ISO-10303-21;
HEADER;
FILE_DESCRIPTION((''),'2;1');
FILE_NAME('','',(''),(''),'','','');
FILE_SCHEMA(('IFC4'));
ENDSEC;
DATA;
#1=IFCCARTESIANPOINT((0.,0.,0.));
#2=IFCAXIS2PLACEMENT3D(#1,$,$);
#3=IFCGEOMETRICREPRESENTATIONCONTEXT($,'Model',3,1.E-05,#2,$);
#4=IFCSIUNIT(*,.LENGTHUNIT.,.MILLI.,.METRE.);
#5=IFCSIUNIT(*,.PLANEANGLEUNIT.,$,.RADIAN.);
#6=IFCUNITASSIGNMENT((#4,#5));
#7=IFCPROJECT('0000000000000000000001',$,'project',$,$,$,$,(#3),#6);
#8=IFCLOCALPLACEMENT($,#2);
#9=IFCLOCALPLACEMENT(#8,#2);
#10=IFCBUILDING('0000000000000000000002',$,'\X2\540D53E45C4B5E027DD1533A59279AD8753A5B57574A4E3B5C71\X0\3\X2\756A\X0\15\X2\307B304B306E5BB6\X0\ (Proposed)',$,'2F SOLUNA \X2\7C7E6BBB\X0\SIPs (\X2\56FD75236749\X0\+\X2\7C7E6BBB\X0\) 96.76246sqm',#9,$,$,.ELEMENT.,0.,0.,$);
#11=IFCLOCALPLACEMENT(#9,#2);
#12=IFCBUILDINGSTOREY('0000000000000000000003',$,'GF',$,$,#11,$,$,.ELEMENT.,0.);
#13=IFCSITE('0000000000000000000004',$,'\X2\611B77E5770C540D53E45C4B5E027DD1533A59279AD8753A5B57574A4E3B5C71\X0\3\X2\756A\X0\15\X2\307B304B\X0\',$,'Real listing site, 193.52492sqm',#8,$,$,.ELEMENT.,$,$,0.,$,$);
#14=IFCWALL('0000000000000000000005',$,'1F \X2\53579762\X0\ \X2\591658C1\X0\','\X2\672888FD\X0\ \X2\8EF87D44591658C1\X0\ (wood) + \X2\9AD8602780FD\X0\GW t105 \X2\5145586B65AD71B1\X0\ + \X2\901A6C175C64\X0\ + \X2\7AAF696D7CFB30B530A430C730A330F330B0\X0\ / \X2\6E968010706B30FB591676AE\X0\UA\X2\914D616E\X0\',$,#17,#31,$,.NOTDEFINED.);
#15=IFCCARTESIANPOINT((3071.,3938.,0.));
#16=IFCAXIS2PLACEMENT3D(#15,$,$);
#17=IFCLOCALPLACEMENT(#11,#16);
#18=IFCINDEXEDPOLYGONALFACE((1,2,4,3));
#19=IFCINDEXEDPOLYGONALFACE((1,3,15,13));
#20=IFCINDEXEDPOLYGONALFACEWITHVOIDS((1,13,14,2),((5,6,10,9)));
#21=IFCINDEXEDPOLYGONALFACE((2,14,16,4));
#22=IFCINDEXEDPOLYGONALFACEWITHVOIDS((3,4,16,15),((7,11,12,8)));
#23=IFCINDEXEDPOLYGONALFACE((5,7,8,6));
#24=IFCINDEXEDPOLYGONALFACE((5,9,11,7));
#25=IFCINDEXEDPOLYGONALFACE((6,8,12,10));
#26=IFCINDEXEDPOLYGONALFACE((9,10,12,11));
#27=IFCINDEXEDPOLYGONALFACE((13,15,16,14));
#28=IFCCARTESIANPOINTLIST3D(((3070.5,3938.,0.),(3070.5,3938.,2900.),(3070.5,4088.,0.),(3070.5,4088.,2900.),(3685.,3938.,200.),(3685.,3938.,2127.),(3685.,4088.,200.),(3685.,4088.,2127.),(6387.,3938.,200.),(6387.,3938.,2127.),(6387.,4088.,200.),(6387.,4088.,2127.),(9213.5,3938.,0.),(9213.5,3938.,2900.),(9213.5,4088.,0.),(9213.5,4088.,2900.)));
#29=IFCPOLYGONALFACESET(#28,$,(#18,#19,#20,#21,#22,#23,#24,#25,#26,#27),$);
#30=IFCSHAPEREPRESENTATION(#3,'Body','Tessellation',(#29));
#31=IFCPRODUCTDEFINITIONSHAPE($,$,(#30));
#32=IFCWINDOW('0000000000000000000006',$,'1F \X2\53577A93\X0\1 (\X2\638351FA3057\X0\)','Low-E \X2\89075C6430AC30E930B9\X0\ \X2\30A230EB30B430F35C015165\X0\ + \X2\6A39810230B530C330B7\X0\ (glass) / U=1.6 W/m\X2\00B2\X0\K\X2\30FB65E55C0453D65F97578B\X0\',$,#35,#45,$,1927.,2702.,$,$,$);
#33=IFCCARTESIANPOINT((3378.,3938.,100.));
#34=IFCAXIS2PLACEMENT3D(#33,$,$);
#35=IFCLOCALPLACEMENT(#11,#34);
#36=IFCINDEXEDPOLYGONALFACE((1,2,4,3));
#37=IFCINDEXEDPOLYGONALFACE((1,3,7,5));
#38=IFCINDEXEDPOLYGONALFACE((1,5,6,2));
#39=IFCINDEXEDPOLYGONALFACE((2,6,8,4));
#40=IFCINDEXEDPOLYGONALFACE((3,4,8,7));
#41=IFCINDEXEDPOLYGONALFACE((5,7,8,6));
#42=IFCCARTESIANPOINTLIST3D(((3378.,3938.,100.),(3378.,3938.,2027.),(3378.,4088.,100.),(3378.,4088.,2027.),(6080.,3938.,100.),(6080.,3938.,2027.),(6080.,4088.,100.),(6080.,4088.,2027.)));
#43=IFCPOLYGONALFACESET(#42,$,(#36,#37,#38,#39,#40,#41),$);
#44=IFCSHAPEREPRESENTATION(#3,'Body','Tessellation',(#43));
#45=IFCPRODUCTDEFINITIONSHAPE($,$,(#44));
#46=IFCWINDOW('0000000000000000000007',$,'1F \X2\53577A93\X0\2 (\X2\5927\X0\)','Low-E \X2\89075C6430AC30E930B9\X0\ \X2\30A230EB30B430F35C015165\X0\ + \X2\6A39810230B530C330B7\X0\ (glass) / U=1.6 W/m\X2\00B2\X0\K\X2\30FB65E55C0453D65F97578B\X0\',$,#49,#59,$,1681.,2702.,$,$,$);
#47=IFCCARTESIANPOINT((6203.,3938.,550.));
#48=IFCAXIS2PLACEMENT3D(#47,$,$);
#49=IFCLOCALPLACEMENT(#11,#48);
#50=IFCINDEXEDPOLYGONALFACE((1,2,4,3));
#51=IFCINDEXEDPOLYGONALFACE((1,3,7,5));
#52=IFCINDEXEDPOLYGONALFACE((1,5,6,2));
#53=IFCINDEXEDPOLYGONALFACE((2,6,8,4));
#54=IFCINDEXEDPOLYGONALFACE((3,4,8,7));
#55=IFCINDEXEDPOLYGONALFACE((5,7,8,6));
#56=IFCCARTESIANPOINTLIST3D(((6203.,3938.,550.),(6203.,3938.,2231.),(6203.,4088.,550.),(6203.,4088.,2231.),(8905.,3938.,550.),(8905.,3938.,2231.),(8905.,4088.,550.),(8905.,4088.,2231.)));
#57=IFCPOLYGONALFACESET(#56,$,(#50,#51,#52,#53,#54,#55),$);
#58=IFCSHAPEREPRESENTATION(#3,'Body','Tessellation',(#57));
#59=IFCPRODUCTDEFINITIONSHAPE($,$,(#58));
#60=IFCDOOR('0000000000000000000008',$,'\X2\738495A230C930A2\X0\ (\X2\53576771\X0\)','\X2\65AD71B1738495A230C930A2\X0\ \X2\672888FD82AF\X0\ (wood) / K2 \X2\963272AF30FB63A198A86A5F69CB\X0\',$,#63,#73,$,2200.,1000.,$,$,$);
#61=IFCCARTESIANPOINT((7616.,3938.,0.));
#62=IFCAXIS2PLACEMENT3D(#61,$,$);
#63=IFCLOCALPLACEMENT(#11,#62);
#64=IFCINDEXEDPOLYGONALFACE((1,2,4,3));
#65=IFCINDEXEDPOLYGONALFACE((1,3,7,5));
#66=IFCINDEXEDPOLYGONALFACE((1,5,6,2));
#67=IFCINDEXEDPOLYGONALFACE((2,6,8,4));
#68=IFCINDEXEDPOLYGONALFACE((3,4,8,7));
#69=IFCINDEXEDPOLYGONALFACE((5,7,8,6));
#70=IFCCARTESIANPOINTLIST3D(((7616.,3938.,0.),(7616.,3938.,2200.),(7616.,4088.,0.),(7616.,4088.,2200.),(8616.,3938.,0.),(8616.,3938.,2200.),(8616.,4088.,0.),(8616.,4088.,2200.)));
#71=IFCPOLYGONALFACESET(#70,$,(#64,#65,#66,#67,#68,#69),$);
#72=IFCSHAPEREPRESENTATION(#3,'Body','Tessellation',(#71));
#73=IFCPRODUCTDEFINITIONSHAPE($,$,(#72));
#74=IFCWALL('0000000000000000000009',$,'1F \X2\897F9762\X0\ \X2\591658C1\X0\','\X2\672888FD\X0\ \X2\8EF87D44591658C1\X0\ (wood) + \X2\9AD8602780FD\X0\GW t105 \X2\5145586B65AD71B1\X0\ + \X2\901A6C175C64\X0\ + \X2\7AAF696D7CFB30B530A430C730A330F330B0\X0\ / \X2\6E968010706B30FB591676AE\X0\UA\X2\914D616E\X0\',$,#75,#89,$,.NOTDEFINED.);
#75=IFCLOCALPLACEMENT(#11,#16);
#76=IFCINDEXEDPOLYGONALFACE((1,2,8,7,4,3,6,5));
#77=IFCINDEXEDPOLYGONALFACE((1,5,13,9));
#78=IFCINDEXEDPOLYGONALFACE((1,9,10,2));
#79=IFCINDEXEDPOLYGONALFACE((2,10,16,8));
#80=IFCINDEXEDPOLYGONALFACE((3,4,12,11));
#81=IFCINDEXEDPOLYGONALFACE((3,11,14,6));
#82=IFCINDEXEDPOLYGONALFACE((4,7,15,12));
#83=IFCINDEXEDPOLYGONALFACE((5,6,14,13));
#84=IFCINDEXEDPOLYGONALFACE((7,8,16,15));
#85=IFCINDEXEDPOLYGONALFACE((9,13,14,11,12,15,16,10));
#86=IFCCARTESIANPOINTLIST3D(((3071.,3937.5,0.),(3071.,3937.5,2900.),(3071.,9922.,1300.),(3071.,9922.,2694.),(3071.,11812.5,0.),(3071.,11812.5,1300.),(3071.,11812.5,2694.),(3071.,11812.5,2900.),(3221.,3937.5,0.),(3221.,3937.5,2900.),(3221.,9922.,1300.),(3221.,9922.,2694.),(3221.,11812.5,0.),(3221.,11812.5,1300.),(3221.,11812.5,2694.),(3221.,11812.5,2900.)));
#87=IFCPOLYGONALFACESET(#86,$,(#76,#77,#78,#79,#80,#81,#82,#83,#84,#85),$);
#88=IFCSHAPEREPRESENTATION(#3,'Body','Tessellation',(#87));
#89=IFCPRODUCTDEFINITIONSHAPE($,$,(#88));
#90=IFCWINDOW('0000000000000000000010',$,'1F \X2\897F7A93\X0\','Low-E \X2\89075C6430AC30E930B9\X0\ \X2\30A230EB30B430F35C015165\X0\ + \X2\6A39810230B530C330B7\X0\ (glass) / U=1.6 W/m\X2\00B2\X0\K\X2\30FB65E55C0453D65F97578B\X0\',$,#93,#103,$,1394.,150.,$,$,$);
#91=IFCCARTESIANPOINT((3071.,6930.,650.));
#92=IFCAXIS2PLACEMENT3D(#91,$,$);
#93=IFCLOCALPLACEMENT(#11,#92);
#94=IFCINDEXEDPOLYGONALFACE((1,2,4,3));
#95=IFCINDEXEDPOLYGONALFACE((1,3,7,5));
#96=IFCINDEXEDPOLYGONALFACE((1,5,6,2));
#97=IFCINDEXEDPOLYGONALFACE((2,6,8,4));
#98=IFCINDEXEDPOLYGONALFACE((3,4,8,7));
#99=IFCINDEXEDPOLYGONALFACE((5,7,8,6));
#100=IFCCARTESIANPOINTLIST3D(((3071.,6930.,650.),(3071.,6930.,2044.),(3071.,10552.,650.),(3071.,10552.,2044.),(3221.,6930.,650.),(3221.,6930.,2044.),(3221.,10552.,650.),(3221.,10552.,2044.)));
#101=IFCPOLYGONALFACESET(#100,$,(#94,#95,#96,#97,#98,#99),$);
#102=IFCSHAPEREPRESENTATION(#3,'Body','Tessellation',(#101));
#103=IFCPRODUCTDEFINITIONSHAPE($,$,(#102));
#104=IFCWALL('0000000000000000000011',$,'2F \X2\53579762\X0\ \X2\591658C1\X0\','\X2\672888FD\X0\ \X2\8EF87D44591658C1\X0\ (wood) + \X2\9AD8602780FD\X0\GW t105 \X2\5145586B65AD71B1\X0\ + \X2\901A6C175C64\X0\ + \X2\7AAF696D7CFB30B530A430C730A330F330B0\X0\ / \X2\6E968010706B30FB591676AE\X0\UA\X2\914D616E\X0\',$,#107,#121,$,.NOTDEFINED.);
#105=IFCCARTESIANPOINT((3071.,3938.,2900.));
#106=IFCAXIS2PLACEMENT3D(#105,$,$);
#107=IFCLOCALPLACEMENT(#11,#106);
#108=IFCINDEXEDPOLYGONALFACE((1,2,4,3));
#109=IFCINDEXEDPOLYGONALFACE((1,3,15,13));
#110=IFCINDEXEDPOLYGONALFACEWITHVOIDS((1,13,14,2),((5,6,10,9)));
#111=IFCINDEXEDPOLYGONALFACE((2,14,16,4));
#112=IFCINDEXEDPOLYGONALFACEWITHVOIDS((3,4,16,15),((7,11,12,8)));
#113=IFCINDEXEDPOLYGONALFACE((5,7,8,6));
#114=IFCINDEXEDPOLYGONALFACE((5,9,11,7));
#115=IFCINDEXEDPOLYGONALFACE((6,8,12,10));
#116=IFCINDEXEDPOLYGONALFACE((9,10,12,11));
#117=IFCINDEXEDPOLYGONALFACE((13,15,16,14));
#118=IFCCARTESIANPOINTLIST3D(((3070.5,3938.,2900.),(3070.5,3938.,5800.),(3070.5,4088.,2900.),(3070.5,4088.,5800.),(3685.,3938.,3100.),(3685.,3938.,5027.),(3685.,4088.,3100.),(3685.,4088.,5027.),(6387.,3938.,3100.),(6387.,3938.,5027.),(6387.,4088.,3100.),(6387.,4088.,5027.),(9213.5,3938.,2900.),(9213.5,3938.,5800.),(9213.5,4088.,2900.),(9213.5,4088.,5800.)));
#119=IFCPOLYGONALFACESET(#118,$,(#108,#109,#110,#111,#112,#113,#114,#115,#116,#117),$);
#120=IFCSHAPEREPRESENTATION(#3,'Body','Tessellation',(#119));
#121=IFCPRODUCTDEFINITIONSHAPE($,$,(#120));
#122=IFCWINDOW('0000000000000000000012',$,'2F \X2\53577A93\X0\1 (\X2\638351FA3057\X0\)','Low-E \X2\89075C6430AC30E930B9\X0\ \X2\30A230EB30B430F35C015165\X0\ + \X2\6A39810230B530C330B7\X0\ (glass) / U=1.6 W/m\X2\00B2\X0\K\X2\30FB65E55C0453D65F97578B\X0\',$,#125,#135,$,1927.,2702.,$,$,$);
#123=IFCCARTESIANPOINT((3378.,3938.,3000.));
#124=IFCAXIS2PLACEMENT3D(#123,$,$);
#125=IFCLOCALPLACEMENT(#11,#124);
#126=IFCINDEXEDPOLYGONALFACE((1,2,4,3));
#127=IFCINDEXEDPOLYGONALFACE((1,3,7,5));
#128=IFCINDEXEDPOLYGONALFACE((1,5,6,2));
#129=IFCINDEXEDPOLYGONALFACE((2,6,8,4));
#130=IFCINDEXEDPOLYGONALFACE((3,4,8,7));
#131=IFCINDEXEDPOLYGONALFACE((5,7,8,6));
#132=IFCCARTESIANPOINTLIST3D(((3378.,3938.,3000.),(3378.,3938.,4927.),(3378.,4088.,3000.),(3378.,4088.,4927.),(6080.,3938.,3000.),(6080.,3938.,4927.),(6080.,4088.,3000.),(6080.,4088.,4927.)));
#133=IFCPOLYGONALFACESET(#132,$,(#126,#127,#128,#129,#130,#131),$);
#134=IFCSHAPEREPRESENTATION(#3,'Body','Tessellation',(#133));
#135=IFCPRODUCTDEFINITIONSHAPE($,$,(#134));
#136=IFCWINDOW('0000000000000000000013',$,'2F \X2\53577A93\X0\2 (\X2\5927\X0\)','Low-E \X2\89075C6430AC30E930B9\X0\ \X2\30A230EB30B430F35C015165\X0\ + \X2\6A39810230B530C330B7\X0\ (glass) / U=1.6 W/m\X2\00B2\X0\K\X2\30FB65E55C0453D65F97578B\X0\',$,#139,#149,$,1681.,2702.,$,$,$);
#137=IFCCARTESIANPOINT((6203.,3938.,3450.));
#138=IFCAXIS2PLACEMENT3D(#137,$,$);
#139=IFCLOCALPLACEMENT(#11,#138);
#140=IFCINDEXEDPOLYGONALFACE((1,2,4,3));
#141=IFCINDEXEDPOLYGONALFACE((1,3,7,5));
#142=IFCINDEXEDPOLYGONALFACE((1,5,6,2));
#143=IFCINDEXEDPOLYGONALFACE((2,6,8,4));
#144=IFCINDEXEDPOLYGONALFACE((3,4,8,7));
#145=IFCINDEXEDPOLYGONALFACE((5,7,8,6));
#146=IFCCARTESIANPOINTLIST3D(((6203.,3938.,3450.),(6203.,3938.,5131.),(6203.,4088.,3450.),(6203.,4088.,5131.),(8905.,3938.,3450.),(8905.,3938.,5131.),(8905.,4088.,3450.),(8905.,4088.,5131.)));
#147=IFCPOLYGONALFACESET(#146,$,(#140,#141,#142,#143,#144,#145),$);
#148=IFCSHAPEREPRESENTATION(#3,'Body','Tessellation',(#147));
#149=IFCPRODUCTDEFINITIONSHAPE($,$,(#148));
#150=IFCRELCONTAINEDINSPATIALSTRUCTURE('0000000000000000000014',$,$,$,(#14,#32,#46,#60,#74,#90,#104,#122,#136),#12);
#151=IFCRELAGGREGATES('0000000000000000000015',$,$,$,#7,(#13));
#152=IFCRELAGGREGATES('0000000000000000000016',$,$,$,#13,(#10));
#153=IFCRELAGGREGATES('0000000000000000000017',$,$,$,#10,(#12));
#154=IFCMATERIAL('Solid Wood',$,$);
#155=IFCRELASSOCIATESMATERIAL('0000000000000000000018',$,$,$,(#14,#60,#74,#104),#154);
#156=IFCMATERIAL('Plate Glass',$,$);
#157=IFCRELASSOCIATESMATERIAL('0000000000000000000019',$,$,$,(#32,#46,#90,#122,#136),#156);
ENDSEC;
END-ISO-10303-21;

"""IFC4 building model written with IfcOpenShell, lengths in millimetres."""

from ifc_helpers import new_model, si_unit, frame, frame_2d, origin, place, context, project, spatial, rectangle, extrude, material, element, fill, save


model = new_model("IFC4")

# Units and contexts
model_context = context("Model", 3, precision=1e-05, world=origin())
ifc_project = project(units=[si_unit("LENGTHUNIT", "METRE", prefix="MILLI"), si_unit("PLANEANGLEUNIT", "RADIAN")], contexts=[model_context])

# Site, building, storey
site_placement = place(None, origin())
site = spatial("IfcSite", under=ifc_project, at=site_placement, Name="愛知県名古屋市緑区大高町字坊主山3番15ほか", ObjectType="Real listing site, 193.52492sqm", CompositionType="ELEMENT", RefElevation=0.0)
building_placement = place(site_placement, origin())
building = spatial("IfcBuilding", under=site, at=building_placement, Name="名古屋市緑区大高町字坊主山3番15ほかの家 (Proposed)", ObjectType="2F SOLUNA 籾殻SIPs (国産杉+籾殻) 96.76246sqm", CompositionType="ELEMENT", ElevationOfRefHeight=0.0, ElevationOfTerrain=0.0)
storey_placement = place(building_placement, origin())
storey = spatial("IfcBuildingStorey", under=building, at=storey_placement, Name="GF", CompositionType="ELEMENT", Elevation=0.0)

# Shared definitions
ifc_material_1 = material(Name="Solid Wood")

# Wall, openings, windows, door
wall_1_placement = place(storey_placement, frame((3071.0, 3938.0, 0.0)))
wall_1 = element("IfcWall", 1, at=wall_1_placement, inside=storey, material=ifc_material_1, Name="1F 南面 外壁", Description="木製 軸組外壁 (wood) + 高性能GW t105 充填断熱 + 通気層 + 窯業系サイディング / 準耐火・外皮UA配慮", PredefinedType="NOTDEFINED", context=model_context, shape_type="SweptSolid", body=[
    extrude(rectangle(XDim=6143.0, YDim=150.0, at=frame_2d((3071.0, 75.0))), frame((3071.0, 3938.0, 0.0)), (0.0, 0.0, 1.0), 2900.0),
])
opening_1_placement = place(storey_placement, frame((3378.0, 3938.0, 100.0)))
opening_1 = element("IfcOpeningElement", 2, at=opening_1_placement, cuts=wall_1, PredefinedType="NOTDEFINED", context=model_context, shape_type="SweptSolid", body=[
    extrude(rectangle(XDim=2702.0, YDim=150.0, at=frame_2d((1351.0, 75.0))), frame((3378.0, 3938.0, 100.0)), (0.0, 0.0, 1.0), 1927.0),
])
opening_2_placement = place(storey_placement, frame((6203.0, 3938.0, 550.0)))
opening_2 = element("IfcOpeningElement", 3, at=opening_2_placement, cuts=wall_1, PredefinedType="NOTDEFINED", context=model_context, shape_type="SweptSolid", body=[
    extrude(rectangle(XDim=2702.0, YDim=150.0, at=frame_2d((1351.0, 75.0))), frame((6203.0, 3938.0, 550.0)), (0.0, 0.0, 1.0), 1681.0),
])
opening_3_placement = place(storey_placement, frame((7616.0, 3938.0, 0.0)))
opening_3 = element("IfcOpeningElement", 4, at=opening_3_placement, cuts=wall_1, PredefinedType="NOTDEFINED", context=model_context, shape_type="SweptSolid", body=[
    extrude(rectangle(XDim=1000.0, YDim=150.0, at=frame_2d((500.0, 75.0))), frame((7616.0, 3938.0, 0.0)), (0.0, 0.0, 1.0), 2200.0),
])
ifc_material_2 = material(Name="Plate Glass")
window_1_placement = place(storey_placement, frame((3378.0, 3938.0, 100.0)))
window_1 = element("IfcWindow", 5, at=window_1_placement, inside=storey, material=ifc_material_2, Name="1F 南窓1 (掃出し)", Description="Low-E 複層ガラス アルゴン封入 + 樹脂サッシ (glass) / U=1.6 W/m²K・日射取得型", OverallHeight=1927.0, OverallWidth=2702.0, context=model_context, shape_type="SweptSolid", body=[
    extrude(rectangle(XDim=2702.0, YDim=150.0, at=frame_2d((1351.0, 75.0))), frame((3378.0, 3938.0, 100.0)), (0.0, 0.0, 1.0), 1927.0),
])
fill(opening_1, window_1)
window_2_placement = place(storey_placement, frame((6203.0, 3938.0, 550.0)))
window_2 = element("IfcWindow", 6, at=window_2_placement, inside=storey, material=ifc_material_2, Name="1F 南窓2 (大)", Description="Low-E 複層ガラス アルゴン封入 + 樹脂サッシ (glass) / U=1.6 W/m²K・日射取得型", OverallHeight=1681.0, OverallWidth=2702.0, context=model_context, shape_type="SweptSolid", body=[
    extrude(rectangle(XDim=2702.0, YDim=150.0, at=frame_2d((1351.0, 75.0))), frame((6203.0, 3938.0, 550.0)), (0.0, 0.0, 1.0), 1681.0),
])
fill(opening_2, window_2)
door_placement = place(storey_placement, frame((7616.0, 3938.0, 0.0)))
door = element("IfcDoor", 7, at=door_placement, inside=storey, material=ifc_material_1, Name="玄関ドア (南東)", Description="断熱玄関ドア 木製芯 (wood) / K2 防犯・採風機構", OverallHeight=2200.0, OverallWidth=1000.0, context=model_context, shape_type="SweptSolid", body=[
    extrude(rectangle(XDim=1000.0, YDim=150.0, at=frame_2d((500.0, 75.0))), frame((7616.0, 3938.0, 0.0)), (0.0, 0.0, 1.0), 2200.0),
])
fill(opening_3, door)

# Wall, opening, window
wall_2_placement = place(storey_placement, frame((3071.0, 3938.0, 0.0)))
wall_2 = element("IfcWall", 8, at=wall_2_placement, inside=storey, material=ifc_material_1, Name="1F 西面 外壁", Description="木製 軸組外壁 (wood) + 高性能GW t105 充填断熱 + 通気層 + 窯業系サイディング / 準耐火・外皮UA配慮", PredefinedType="NOTDEFINED", context=model_context, shape_type="SweptSolid", body=[
    extrude(rectangle(XDim=150.0, YDim=7875.0, at=frame_2d((75.0, 3937.0))), frame((3071.0, 3938.0, 0.0)), (0.0, 0.0, 1.0), 2900.0),
])
opening_4_placement = place(storey_placement, frame((3071.0, 6930.0, 650.0)))
opening_4 = element("IfcOpeningElement", 9, at=opening_4_placement, cuts=wall_2, PredefinedType="NOTDEFINED", context=model_context, shape_type="SweptSolid", body=[
    extrude(rectangle(XDim=150.0, YDim=3622.0, at=frame_2d((75.0, 1811.0))), frame((3071.0, 6930.0, 650.0)), (0.0, 0.0, 1.0), 1394.0),
])
window_3_placement = place(storey_placement, frame((3071.0, 6930.0, 650.0)))
window_3 = element("IfcWindow", 10, at=window_3_placement, inside=storey, material=ifc_material_2, Name="1F 西窓", Description="Low-E 複層ガラス アルゴン封入 + 樹脂サッシ (glass) / U=1.6 W/m²K・日射取得型", OverallHeight=1394.0, OverallWidth=150.0, context=model_context, shape_type="SweptSolid", body=[
    extrude(rectangle(XDim=150.0, YDim=3622.0, at=frame_2d((75.0, 1811.0))), frame((3071.0, 6930.0, 650.0)), (0.0, 0.0, 1.0), 1394.0),
])
fill(opening_4, window_3)

# Wall, openings, windows
wall_3_placement = place(storey_placement, frame((3071.0, 3938.0, 2900.0)))
wall_3 = element("IfcWall", 11, at=wall_3_placement, inside=storey, material=ifc_material_1, Name="2F 南面 外壁", Description="木製 軸組外壁 (wood) + 高性能GW t105 充填断熱 + 通気層 + 窯業系サイディング / 準耐火・外皮UA配慮", PredefinedType="NOTDEFINED", context=model_context, shape_type="SweptSolid", body=[
    extrude(rectangle(XDim=6143.0, YDim=150.0, at=frame_2d((3071.0, 75.0))), frame((3071.0, 3938.0, 2900.0)), (0.0, 0.0, 1.0), 2900.0),
])
opening_5_placement = place(storey_placement, frame((3378.0, 3938.0, 3000.0)))
opening_5 = element("IfcOpeningElement", 12, at=opening_5_placement, cuts=wall_3, PredefinedType="NOTDEFINED", context=model_context, shape_type="SweptSolid", body=[
    extrude(rectangle(XDim=2702.0, YDim=150.0, at=frame_2d((1351.0, 75.0))), frame((3378.0, 3938.0, 3000.0)), (0.0, 0.0, 1.0), 1927.0),
])
opening_6_placement = place(storey_placement, frame((6203.0, 3938.0, 3450.0)))
opening_6 = element("IfcOpeningElement", 13, at=opening_6_placement, cuts=wall_3, PredefinedType="NOTDEFINED", context=model_context, shape_type="SweptSolid", body=[
    extrude(rectangle(XDim=2702.0, YDim=150.0, at=frame_2d((1351.0, 75.0))), frame((6203.0, 3938.0, 3450.0)), (0.0, 0.0, 1.0), 1681.0),
])
window_4_placement = place(storey_placement, frame((3378.0, 3938.0, 3000.0)))
window_4 = element("IfcWindow", 14, at=window_4_placement, inside=storey, material=ifc_material_2, Name="2F 南窓1 (掃出し)", Description="Low-E 複層ガラス アルゴン封入 + 樹脂サッシ (glass) / U=1.6 W/m²K・日射取得型", OverallHeight=1927.0, OverallWidth=2702.0, context=model_context, shape_type="SweptSolid", body=[
    extrude(rectangle(XDim=2702.0, YDim=150.0, at=frame_2d((1351.0, 75.0))), frame((3378.0, 3938.0, 3000.0)), (0.0, 0.0, 1.0), 1927.0),
])
fill(opening_5, window_4)
window_5_placement = place(storey_placement, frame((6203.0, 3938.0, 3450.0)))
window_5 = element("IfcWindow", 15, at=window_5_placement, inside=storey, material=ifc_material_2, Name="2F 南窓2 (大)", Description="Low-E 複層ガラス アルゴン封入 + 樹脂サッシ (glass) / U=1.6 W/m²K・日射取得型", OverallHeight=1681.0, OverallWidth=2702.0, context=model_context, shape_type="SweptSolid", body=[
    extrude(rectangle(XDim=2702.0, YDim=150.0, at=frame_2d((1351.0, 75.0))), frame((6203.0, 3938.0, 3450.0)), (0.0, 0.0, 1.0), 1681.0),
])
fill(opening_6, window_5)

save(model, "model.ifc")
